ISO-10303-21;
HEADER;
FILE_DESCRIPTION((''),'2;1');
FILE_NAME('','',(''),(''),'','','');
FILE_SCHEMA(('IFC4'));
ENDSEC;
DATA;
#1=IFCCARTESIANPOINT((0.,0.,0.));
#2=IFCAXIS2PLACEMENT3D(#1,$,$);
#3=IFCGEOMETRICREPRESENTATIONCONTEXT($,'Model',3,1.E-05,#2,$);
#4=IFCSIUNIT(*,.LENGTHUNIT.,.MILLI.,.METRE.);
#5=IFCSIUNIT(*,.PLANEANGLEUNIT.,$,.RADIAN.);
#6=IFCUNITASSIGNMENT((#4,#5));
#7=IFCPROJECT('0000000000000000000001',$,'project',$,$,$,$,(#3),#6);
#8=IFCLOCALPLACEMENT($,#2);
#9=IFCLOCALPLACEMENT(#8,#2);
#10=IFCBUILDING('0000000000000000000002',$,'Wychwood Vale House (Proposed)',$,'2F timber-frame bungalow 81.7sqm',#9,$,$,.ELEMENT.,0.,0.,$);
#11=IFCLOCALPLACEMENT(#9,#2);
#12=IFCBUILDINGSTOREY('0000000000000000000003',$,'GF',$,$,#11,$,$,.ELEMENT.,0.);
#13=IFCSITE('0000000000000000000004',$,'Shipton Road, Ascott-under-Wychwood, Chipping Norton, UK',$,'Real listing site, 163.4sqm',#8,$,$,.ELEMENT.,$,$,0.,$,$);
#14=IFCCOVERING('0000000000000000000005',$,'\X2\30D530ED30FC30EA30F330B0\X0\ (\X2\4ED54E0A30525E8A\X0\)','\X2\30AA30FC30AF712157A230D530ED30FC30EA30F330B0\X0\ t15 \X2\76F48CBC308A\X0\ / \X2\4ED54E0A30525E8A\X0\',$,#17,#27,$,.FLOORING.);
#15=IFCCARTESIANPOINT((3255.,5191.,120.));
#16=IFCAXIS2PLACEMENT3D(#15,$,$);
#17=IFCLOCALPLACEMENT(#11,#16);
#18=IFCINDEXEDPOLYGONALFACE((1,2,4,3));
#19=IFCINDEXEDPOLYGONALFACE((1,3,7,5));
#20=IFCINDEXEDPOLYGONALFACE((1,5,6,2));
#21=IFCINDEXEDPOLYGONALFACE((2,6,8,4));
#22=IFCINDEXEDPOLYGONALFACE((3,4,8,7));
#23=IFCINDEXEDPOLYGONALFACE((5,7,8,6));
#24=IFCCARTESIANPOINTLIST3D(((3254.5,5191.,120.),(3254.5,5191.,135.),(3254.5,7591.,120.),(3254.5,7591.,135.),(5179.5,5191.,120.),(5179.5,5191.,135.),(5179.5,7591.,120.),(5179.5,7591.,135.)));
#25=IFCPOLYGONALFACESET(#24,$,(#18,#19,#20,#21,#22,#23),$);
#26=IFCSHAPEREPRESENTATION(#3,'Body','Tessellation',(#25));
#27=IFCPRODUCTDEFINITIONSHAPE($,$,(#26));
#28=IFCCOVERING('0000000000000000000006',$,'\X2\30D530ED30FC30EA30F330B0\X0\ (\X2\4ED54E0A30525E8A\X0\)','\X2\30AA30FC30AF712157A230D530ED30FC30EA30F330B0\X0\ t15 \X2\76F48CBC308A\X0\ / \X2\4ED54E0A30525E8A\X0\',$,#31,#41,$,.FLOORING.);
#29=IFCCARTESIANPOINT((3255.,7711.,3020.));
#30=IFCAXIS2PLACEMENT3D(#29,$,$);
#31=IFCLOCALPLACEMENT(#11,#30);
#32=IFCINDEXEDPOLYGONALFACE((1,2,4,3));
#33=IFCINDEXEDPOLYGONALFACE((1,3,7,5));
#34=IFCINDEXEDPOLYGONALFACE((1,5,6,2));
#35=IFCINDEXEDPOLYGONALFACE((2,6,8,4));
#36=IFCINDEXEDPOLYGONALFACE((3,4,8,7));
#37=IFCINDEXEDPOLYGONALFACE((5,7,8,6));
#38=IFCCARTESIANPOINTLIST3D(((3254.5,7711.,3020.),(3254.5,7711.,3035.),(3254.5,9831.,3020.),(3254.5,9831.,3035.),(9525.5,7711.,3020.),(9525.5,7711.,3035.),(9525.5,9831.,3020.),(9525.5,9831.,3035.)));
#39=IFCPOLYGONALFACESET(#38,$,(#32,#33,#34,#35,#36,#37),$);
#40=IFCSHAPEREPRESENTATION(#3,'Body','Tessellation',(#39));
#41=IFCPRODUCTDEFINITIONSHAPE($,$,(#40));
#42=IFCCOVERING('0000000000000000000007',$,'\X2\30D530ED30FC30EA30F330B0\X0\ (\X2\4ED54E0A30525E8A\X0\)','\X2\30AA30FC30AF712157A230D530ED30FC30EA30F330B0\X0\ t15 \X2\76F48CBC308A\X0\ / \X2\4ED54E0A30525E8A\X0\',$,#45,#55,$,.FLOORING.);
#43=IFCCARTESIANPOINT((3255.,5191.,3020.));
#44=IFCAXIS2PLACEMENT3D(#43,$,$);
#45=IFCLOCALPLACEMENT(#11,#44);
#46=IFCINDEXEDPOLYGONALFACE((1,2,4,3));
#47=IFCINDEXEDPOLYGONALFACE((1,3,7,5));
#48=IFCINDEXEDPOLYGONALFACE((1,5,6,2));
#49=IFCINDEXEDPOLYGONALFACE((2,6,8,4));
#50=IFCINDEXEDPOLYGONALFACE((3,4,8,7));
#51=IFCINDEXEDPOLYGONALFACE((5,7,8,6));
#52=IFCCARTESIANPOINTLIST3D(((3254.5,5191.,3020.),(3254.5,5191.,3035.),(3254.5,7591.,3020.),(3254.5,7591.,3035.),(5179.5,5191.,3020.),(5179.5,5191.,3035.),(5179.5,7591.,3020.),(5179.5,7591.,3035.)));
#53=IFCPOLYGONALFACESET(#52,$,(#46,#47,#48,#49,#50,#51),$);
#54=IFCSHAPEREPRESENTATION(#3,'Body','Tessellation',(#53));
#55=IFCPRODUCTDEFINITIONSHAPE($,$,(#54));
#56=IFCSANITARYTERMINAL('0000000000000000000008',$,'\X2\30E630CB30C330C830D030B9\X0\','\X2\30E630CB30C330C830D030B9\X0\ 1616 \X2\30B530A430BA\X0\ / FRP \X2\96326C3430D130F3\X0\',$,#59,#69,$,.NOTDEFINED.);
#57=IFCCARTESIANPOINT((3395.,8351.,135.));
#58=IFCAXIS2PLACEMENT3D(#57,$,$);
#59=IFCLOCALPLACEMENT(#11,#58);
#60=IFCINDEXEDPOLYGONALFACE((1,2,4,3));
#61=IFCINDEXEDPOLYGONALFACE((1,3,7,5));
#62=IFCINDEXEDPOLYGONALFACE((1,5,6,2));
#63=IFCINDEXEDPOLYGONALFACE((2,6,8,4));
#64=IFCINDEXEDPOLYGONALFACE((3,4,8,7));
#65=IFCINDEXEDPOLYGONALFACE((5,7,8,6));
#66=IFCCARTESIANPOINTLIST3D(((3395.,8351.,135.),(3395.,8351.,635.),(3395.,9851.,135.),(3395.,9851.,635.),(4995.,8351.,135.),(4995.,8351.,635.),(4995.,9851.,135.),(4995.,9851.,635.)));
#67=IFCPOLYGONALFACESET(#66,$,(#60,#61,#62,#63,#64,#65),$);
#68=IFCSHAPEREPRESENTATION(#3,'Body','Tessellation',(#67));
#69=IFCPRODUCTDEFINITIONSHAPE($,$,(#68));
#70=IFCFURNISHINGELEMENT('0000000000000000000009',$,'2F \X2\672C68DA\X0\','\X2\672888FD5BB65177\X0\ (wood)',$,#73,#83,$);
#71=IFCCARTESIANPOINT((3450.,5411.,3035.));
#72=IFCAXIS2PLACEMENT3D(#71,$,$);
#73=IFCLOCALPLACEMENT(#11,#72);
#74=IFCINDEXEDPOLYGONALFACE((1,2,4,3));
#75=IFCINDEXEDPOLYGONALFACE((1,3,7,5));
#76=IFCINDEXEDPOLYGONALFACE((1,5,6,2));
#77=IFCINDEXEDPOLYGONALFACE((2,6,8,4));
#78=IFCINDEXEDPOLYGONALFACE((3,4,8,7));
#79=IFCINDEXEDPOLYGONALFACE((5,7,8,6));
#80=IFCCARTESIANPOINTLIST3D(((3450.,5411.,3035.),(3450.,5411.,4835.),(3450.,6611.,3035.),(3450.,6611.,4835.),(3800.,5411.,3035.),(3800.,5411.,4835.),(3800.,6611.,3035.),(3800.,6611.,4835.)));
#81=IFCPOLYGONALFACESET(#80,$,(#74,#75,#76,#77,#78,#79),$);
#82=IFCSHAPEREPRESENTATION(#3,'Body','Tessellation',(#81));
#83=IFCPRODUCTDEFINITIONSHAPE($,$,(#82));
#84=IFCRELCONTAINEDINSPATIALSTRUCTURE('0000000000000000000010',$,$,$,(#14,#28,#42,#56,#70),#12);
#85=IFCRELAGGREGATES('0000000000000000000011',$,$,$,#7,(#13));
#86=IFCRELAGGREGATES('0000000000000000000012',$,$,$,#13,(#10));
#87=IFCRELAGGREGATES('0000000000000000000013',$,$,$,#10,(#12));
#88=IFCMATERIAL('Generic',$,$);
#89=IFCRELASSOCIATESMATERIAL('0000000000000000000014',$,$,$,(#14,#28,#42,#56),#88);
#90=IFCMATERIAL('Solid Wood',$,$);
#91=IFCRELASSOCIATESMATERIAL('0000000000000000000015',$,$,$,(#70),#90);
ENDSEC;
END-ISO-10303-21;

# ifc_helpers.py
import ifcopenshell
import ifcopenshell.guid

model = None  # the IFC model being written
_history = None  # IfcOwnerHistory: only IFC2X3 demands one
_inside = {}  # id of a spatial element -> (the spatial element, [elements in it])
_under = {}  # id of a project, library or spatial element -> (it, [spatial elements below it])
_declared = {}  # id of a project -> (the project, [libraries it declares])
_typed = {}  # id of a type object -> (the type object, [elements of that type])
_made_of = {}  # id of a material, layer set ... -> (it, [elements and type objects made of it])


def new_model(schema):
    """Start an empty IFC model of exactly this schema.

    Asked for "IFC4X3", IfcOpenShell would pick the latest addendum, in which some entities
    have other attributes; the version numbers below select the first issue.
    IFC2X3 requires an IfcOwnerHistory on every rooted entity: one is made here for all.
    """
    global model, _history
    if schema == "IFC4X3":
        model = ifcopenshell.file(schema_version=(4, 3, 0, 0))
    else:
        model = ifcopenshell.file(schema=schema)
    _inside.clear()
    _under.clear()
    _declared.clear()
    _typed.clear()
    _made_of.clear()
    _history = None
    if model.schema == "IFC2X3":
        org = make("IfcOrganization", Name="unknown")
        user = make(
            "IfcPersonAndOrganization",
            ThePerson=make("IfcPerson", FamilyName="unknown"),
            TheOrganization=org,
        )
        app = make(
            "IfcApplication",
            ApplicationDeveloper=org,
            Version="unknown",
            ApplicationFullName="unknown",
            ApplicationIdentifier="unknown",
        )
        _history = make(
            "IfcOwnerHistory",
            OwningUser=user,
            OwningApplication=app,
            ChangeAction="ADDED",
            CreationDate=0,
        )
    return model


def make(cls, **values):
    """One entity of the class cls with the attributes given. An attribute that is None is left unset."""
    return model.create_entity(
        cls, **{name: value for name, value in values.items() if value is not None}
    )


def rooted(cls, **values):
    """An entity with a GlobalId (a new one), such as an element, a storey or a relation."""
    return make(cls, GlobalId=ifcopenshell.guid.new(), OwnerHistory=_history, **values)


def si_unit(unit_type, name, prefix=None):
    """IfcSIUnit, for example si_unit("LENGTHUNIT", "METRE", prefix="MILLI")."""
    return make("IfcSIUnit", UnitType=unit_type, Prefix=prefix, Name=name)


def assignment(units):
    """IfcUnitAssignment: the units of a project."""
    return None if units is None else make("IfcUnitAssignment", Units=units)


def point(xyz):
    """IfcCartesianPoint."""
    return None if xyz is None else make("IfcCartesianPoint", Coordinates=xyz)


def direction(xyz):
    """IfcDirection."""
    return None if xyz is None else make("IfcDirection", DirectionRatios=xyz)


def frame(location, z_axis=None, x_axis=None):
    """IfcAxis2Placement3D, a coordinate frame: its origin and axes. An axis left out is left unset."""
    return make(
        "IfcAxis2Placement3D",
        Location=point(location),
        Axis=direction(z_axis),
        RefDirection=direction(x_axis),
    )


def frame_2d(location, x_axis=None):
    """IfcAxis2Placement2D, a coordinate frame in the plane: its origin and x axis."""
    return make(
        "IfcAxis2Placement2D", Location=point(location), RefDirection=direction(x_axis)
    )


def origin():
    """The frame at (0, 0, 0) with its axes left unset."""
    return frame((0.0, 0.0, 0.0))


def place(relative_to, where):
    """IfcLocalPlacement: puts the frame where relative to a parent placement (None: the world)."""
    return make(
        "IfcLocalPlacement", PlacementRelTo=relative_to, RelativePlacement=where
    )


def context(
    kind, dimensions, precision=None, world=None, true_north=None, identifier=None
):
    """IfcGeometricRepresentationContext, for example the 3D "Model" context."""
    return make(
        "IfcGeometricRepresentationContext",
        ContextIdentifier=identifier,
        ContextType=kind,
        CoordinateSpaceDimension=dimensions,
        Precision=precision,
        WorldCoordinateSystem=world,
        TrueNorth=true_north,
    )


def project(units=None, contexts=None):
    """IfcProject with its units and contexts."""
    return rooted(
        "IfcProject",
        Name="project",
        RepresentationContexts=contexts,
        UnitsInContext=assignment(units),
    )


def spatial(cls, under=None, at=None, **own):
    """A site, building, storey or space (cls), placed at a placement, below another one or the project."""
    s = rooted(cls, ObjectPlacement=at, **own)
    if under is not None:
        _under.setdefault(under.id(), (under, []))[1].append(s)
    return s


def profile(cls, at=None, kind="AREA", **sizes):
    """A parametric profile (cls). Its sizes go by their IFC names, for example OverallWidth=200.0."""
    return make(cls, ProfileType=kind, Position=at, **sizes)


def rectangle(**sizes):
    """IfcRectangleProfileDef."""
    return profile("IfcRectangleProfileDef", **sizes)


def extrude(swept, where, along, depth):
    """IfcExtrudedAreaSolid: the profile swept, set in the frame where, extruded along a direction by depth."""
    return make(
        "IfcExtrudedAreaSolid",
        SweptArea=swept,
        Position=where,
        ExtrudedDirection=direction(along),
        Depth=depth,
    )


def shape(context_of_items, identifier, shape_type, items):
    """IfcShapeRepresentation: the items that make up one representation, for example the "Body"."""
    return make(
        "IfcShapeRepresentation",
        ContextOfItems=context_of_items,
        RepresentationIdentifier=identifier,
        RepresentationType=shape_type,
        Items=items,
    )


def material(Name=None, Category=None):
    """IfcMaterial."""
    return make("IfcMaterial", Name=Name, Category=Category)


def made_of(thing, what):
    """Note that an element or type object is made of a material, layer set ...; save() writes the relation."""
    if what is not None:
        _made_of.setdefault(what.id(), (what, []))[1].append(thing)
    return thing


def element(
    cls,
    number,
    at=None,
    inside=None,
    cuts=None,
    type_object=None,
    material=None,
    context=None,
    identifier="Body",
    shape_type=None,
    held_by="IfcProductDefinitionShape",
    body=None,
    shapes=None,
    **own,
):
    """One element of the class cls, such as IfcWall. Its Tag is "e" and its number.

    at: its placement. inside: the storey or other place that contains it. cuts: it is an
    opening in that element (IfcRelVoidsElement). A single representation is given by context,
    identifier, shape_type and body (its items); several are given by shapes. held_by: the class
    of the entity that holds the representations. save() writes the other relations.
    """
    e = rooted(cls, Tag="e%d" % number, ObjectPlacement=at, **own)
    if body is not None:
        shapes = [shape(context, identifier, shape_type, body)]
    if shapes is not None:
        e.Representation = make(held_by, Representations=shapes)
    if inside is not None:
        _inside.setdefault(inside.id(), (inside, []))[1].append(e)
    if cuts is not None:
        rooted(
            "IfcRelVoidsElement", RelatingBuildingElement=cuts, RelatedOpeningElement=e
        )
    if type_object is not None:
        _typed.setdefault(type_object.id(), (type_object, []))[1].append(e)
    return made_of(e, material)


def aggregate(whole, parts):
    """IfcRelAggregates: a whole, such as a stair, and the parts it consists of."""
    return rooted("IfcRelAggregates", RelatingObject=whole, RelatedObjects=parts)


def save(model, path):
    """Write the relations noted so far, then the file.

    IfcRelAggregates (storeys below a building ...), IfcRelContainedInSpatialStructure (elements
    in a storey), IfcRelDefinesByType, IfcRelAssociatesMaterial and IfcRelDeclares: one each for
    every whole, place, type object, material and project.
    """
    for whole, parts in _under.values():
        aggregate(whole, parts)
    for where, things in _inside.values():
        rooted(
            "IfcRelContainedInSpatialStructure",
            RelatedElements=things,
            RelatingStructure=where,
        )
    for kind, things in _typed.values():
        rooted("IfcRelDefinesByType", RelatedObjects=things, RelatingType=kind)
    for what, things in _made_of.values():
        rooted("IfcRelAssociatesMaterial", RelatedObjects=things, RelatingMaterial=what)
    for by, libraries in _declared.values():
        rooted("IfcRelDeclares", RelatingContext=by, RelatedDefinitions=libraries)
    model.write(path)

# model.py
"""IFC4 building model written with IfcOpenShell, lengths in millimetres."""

from ifc_helpers import new_model, si_unit, frame, frame_2d, origin, place, context, project, spatial, rectangle, extrude, material, element, save


model = new_model("IFC4")

# Units and contexts
model_context = context("Model", 3, precision=1e-05, world=origin())
ifc_project = project(units=[si_unit("LENGTHUNIT", "METRE", prefix="MILLI"), si_unit("PLANEANGLEUNIT", "RADIAN")], contexts=[model_context])

# Site, building, storey
site_placement = place(None, origin())
site = spatial("IfcSite", under=ifc_project, at=site_placement, Name="Shipton Road, Ascott-under-Wychwood, Chipping Norton, UK", ObjectType="Real listing site, 163.4sqm", CompositionType="ELEMENT", RefElevation=0.0)
building_placement = place(site_placement, origin())
building = spatial("IfcBuilding", under=site, at=building_placement, Name="Wychwood Vale House (Proposed)", ObjectType="2F timber-frame bungalow 81.7sqm", CompositionType="ELEMENT", ElevationOfRefHeight=0.0, ElevationOfTerrain=0.0)
storey_placement = place(building_placement, origin())
storey = spatial("IfcBuildingStorey", under=building, at=storey_placement, Name="GF", CompositionType="ELEMENT", Elevation=0.0)

# Shared definitions
ifc_material_1 = material(Name="Solid Wood")

# Coverings
ifc_material_2 = material(Name="Generic")
covering_1_placement = place(storey_placement, frame((3255.0, 5191.0, 120.0)))
element("IfcCovering", 1, at=covering_1_placement, inside=storey, material=ifc_material_2, Name="フローリング (仕上げ床)", Description="オーク無垢フローリング t15 直貼り / 仕上げ床", PredefinedType="FLOORING", context=model_context, shape_type="SweptSolid", body=[
    extrude(rectangle(XDim=1925.0, YDim=2400.0, at=frame_2d((962.0, 1200.0))), frame((3255.0, 5191.0, 120.0)), (0.0, 0.0, 1.0), 15.0),
])
covering_2_placement = place(storey_placement, frame((3255.0, 7711.0, 3020.0)))
element("IfcCovering", 2, at=covering_2_placement, inside=storey, material=ifc_material_2, Name="フローリング (仕上げ床)", Description="オーク無垢フローリング t15 直貼り / 仕上げ床", PredefinedType="FLOORING", context=model_context, shape_type="SweptSolid", body=[
    extrude(rectangle(XDim=6271.0, YDim=2120.0, at=frame_2d((3135.0, 1060.0))), frame((3255.0, 7711.0, 3020.0)), (0.0, 0.0, 1.0), 15.0),
])
covering_3_placement = place(storey_placement, frame((3255.0, 5191.0, 3020.0)))
element("IfcCovering", 3, at=covering_3_placement, inside=storey, material=ifc_material_2, Name="フローリング (仕上げ床)", Description="オーク無垢フローリング t15 直貼り / 仕上げ床", PredefinedType="FLOORING", context=model_context, shape_type="SweptSolid", body=[
    extrude(rectangle(XDim=1925.0, YDim=2400.0, at=frame_2d((962.0, 1200.0))), frame((3255.0, 5191.0, 3020.0)), (0.0, 0.0, 1.0), 15.0),
])

# Sanitary terminal
sanitary_terminal_placement = place(storey_placement, frame((3395.0, 8351.0, 135.0)))
element("IfcSanitaryTerminal", 4, at=sanitary_terminal_placement, inside=storey, material=ifc_material_2, Name="ユニットバス", Description="ユニットバス 1616 サイズ / FRP 防水パン", PredefinedType="NOTDEFINED", context=model_context, shape_type="SweptSolid", body=[
    extrude(rectangle(XDim=1600.0, YDim=1500.0, at=frame_2d((800.0, 750.0))), frame((3395.0, 8351.0, 135.0)), (0.0, 0.0, 1.0), 500.0),
])

# Furnishing element
furnishing_placement = place(storey_placement, frame((3450.0, 5411.0, 3035.0)))
element("IfcFurnishingElement", 5, at=furnishing_placement, inside=storey, material=ifc_material_1, Name="2F 本棚", Description="木製家具 (wood)", context=model_context, shape_type="SweptSolid", body=[
    extrude(rectangle(XDim=350.0, YDim=1200.0, at=frame_2d((175.0, 600.0))), frame((3450.0, 5411.0, 3035.0)), (0.0, 0.0, 1.0), 1800.0),
])

save(model, "model.ifc")
